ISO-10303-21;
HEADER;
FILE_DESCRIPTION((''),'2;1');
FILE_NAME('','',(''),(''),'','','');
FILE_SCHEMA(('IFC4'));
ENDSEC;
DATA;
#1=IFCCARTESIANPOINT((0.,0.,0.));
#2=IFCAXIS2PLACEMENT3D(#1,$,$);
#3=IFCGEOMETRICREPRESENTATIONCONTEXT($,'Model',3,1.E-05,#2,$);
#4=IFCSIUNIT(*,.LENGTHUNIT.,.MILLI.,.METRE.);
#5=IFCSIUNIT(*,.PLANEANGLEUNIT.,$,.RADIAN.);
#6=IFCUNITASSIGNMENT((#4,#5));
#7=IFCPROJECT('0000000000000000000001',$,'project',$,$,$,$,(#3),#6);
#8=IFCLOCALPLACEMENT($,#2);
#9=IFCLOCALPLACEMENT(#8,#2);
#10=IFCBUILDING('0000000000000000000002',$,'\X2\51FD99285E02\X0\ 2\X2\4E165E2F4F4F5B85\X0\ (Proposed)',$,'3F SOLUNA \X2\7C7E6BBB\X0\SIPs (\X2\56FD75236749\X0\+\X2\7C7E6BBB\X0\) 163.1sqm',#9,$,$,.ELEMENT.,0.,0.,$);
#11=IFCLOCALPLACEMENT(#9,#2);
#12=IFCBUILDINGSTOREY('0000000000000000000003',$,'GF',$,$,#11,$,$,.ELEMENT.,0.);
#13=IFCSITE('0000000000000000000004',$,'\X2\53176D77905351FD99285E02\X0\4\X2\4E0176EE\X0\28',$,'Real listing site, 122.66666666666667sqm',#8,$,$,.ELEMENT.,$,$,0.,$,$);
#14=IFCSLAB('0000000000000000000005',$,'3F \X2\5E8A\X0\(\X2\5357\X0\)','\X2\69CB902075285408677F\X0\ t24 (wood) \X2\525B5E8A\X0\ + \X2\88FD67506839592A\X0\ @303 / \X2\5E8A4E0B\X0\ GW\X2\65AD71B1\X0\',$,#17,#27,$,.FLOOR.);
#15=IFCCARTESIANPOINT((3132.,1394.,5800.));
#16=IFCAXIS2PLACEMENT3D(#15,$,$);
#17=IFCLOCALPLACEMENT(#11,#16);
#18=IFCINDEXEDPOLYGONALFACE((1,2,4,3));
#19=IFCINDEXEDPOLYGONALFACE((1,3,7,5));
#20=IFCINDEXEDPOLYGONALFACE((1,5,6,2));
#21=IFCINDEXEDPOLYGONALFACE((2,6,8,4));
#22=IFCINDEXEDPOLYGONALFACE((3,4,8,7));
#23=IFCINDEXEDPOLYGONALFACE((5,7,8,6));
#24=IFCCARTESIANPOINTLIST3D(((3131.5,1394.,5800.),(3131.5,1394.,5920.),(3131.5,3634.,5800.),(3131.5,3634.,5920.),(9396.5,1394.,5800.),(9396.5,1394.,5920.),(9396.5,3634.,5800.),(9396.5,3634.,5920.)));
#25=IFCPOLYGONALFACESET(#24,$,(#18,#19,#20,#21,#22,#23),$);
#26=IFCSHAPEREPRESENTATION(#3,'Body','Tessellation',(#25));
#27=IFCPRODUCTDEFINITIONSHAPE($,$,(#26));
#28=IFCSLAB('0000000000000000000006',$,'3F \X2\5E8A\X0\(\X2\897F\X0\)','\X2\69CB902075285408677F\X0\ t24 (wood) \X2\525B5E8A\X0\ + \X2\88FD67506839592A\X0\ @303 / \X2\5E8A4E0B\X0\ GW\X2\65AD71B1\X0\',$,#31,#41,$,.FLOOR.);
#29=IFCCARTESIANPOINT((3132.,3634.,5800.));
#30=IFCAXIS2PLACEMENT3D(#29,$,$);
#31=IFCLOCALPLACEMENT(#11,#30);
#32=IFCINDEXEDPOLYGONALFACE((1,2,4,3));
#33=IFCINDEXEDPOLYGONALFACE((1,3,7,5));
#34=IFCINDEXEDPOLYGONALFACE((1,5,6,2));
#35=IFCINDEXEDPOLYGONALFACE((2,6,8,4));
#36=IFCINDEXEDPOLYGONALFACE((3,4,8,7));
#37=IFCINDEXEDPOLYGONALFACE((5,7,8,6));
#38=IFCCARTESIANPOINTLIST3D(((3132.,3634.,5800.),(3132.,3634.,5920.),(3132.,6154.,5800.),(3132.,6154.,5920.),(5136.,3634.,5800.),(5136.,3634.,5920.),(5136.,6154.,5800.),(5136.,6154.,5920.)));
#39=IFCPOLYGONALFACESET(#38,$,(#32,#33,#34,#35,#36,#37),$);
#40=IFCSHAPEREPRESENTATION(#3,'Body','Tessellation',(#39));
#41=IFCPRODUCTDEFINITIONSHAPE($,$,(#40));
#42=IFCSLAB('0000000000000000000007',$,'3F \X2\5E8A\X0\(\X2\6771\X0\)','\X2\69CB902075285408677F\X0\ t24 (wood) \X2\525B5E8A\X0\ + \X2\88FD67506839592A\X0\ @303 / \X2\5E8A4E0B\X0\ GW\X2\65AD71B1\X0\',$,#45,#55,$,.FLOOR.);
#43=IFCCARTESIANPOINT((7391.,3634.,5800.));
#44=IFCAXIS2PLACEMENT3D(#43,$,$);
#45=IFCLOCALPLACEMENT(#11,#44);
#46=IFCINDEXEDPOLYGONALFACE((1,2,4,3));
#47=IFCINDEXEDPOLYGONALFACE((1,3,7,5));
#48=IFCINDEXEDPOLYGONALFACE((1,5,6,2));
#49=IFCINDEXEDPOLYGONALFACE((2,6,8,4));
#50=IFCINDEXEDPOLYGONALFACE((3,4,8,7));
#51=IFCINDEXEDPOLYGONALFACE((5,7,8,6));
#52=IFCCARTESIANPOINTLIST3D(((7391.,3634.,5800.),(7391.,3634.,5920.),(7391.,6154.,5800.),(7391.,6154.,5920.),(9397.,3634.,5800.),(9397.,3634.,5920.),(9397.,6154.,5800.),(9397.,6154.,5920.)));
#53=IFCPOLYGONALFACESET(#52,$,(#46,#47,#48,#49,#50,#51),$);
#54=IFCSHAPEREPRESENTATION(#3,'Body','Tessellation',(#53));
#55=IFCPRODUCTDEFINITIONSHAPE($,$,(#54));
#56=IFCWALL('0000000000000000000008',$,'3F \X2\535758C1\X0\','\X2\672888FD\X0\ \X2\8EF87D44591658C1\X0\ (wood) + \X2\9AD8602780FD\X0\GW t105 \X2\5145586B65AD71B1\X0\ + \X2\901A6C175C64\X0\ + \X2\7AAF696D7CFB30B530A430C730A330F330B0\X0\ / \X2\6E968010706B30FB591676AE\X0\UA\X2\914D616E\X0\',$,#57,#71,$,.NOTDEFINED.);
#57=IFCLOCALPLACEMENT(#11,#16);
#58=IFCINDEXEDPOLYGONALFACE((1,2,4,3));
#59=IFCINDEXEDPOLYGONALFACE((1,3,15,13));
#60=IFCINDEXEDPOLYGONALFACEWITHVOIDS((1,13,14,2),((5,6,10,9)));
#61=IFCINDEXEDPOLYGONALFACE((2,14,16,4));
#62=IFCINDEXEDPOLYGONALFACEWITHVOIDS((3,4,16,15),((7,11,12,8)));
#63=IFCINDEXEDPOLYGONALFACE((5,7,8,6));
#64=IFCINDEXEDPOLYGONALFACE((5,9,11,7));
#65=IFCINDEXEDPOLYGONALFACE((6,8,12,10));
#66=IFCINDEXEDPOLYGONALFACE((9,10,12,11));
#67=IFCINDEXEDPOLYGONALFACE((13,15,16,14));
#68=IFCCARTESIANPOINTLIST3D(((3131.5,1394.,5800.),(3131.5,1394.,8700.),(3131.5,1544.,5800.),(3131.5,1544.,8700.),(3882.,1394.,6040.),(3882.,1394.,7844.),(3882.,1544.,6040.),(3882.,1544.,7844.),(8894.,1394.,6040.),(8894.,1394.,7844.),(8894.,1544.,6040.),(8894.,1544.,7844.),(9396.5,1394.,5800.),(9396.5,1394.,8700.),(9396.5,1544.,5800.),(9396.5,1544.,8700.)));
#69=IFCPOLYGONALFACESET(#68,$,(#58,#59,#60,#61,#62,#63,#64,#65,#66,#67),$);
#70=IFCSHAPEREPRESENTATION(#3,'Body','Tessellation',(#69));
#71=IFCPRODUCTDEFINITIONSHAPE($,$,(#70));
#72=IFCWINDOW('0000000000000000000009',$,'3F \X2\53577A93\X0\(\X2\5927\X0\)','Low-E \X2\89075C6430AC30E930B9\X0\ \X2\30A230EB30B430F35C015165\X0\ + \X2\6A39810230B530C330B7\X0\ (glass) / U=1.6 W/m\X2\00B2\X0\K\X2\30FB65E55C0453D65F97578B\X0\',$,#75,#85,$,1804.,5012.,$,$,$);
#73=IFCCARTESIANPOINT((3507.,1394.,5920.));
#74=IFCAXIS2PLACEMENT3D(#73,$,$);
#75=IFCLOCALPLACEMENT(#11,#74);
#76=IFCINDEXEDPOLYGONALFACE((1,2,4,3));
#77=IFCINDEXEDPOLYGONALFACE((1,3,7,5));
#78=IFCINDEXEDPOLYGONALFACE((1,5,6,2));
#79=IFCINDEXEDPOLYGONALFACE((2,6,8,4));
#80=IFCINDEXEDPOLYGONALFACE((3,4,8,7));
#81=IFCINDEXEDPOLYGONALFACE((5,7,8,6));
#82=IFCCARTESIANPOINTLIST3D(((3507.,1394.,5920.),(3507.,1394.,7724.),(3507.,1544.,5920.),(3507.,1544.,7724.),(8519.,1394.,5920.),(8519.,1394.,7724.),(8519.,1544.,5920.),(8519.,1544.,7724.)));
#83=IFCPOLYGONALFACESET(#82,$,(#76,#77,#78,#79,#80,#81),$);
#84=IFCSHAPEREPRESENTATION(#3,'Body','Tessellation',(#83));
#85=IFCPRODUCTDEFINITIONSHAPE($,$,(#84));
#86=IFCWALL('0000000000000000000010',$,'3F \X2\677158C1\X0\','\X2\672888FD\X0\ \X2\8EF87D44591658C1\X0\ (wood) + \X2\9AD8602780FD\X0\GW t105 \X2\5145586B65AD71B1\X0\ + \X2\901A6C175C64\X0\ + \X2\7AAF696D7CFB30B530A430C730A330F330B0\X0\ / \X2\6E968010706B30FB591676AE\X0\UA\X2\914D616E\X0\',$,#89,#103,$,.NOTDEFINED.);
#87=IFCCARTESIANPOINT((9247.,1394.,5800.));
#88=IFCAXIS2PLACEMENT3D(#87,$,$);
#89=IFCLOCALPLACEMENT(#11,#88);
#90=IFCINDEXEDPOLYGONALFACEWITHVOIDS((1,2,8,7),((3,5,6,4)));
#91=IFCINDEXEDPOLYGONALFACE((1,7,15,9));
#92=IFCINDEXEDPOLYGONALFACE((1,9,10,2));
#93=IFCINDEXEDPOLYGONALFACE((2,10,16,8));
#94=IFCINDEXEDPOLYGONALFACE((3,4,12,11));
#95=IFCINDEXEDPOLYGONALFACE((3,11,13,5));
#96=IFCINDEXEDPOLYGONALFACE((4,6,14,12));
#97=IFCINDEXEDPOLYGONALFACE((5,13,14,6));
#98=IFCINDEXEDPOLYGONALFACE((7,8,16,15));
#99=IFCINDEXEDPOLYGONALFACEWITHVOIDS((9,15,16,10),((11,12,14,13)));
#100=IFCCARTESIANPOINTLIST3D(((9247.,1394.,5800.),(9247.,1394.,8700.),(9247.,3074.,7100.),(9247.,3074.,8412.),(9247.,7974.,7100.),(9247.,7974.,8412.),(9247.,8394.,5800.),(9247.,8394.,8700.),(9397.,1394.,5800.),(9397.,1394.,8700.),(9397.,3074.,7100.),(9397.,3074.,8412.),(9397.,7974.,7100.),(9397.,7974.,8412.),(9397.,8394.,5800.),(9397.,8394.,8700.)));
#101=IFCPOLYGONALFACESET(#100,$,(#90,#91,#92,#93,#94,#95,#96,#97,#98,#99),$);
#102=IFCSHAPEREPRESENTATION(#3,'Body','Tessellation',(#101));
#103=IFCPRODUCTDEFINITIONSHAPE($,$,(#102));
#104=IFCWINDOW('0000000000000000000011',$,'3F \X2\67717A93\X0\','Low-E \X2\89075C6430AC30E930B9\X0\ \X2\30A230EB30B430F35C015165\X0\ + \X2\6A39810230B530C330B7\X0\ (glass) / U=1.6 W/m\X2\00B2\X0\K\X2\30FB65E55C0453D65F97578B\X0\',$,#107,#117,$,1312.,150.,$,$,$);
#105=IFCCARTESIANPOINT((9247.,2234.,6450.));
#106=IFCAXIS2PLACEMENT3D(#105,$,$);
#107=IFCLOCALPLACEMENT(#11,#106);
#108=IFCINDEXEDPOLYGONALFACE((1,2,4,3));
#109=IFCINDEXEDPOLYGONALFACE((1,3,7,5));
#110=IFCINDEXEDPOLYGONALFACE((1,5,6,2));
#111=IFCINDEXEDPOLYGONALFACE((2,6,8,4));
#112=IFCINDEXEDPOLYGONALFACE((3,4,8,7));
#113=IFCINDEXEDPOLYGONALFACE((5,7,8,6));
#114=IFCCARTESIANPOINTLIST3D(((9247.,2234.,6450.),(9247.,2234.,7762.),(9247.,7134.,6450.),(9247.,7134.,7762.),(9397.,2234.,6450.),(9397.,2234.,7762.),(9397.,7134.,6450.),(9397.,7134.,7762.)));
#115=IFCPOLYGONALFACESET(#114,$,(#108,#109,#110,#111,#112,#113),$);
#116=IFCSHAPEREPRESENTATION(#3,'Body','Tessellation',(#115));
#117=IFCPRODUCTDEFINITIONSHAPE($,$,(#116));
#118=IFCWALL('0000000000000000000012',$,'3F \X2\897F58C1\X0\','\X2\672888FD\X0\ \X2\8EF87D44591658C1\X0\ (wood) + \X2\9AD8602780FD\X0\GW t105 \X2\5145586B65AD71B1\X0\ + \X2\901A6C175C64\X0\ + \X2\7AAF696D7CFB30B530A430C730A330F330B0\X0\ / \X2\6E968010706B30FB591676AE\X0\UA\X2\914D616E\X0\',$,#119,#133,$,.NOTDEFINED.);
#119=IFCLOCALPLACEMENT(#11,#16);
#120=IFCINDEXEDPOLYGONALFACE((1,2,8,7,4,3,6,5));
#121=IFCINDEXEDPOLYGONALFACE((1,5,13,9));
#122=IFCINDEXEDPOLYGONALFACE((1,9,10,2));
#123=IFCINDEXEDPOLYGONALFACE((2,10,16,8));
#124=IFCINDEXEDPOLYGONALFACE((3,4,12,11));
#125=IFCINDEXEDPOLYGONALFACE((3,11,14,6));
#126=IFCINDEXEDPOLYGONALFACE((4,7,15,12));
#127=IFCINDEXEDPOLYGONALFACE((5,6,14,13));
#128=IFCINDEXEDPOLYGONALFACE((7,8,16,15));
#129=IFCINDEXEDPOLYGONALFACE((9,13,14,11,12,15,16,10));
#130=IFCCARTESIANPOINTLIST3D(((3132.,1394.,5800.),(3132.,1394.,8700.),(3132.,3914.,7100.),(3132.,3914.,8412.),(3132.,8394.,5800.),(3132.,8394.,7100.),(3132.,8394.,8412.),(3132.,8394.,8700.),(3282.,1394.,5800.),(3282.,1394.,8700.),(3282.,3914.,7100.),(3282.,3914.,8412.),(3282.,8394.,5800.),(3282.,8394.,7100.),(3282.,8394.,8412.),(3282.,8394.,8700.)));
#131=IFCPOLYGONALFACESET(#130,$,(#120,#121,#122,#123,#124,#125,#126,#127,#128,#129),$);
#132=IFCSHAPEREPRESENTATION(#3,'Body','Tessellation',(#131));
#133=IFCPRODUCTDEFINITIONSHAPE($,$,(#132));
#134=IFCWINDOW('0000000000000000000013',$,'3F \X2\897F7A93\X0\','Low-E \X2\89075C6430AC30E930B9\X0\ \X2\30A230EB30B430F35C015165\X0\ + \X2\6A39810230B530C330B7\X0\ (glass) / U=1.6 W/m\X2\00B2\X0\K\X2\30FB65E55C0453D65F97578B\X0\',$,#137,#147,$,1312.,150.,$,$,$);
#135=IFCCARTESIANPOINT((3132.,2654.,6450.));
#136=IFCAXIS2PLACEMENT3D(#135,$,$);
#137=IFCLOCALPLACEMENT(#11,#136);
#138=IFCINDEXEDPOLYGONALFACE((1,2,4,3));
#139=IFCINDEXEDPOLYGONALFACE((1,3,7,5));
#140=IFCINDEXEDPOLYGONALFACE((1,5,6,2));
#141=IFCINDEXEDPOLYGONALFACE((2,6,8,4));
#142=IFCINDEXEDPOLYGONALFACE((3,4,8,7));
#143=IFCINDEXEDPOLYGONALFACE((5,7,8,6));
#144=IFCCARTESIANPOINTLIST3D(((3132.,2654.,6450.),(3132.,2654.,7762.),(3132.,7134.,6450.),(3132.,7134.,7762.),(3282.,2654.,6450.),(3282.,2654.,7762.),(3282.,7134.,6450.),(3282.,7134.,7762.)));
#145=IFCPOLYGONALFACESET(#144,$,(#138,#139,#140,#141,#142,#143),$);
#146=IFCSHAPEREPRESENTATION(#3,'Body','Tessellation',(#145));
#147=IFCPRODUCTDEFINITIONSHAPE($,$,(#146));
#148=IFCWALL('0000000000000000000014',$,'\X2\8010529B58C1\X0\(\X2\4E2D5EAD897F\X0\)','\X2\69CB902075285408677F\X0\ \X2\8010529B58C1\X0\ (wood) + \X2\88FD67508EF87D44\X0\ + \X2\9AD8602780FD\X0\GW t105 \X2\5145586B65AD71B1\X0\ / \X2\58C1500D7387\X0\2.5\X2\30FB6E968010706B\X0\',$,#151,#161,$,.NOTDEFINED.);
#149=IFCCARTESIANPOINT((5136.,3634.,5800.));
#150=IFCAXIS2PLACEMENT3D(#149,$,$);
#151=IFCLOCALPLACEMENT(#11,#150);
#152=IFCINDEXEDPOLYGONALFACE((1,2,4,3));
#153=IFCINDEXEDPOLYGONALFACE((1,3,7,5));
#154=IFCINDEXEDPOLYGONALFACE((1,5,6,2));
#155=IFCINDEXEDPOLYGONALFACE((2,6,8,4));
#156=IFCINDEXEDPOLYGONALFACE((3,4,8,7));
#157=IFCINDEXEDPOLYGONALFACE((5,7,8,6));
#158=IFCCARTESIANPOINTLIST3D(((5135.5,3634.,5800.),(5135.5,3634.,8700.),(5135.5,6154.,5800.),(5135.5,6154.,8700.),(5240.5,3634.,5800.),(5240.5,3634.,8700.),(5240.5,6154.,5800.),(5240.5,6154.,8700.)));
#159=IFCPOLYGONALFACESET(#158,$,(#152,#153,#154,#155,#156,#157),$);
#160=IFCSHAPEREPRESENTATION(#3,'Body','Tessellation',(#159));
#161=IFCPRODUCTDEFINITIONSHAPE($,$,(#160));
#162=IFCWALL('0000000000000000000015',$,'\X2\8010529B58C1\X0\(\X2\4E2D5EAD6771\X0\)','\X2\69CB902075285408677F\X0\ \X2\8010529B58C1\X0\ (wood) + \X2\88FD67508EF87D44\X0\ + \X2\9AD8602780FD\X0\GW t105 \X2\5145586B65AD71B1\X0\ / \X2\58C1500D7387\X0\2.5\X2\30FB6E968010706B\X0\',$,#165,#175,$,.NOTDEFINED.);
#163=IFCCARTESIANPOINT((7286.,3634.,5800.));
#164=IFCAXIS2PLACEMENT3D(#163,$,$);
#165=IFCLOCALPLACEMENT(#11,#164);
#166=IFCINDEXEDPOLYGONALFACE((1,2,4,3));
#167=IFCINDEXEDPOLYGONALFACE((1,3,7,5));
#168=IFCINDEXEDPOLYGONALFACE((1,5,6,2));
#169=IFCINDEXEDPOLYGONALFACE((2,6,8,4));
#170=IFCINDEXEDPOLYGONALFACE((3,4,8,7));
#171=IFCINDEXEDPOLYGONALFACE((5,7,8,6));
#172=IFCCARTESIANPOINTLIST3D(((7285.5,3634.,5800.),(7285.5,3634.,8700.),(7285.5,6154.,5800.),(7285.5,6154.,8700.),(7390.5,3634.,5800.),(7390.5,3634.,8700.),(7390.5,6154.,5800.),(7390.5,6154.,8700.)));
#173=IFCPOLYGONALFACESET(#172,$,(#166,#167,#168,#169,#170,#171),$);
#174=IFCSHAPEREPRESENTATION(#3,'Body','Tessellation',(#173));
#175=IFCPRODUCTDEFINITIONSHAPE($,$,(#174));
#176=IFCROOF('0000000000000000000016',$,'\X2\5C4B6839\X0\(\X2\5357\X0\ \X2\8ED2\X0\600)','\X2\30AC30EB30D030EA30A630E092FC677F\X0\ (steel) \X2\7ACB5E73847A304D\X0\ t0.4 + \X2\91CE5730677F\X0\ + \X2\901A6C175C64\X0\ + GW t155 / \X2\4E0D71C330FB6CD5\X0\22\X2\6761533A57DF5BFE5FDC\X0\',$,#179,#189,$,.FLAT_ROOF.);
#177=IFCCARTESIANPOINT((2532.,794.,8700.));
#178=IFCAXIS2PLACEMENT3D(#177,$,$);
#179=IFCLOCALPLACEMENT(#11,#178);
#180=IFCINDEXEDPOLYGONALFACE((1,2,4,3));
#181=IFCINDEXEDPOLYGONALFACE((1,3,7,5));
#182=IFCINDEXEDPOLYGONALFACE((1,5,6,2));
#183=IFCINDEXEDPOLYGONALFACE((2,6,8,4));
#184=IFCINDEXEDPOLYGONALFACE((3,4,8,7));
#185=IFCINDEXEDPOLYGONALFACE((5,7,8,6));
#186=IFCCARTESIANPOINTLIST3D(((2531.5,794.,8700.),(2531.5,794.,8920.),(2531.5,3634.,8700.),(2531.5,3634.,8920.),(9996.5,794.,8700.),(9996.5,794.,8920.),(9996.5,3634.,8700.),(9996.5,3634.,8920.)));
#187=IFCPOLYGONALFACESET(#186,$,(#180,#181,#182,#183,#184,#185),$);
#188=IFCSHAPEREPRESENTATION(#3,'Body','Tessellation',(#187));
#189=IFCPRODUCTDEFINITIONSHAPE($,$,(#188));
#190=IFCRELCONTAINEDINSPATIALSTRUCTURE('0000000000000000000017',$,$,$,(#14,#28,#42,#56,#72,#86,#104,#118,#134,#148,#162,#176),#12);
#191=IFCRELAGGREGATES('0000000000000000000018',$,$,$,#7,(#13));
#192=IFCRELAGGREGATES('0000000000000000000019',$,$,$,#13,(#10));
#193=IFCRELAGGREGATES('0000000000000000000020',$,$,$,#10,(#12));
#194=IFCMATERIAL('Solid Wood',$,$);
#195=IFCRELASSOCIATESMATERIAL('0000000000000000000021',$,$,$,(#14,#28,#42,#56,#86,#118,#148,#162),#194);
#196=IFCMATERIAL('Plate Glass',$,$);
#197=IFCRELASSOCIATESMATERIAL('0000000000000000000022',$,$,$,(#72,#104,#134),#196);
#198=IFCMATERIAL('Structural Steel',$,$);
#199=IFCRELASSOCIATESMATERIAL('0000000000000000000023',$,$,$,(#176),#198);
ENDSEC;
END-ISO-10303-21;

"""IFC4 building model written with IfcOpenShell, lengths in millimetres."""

from ifc_helpers import new_model, si_unit, frame, frame_2d, origin, place, context, project, spatial, rectangle, extrude, material, element, fill, save


model = new_model("IFC4")

# Units and contexts
model_context = context("Model", 3, precision=1e-05, world=origin())
ifc_project = project(units=[si_unit("LENGTHUNIT", "METRE", prefix="MILLI"), si_unit("PLANEANGLEUNIT", "RADIAN")], contexts=[model_context])

# Site, building, storey
site_placement = place(None, origin())
site = spatial("IfcSite", under=ifc_project, at=site_placement, Name="北海道函館市4丁目28", ObjectType="Real listing site, 122.66666666666667sqm", CompositionType="ELEMENT", RefElevation=0.0)
building_placement = place(site_placement, origin())
building = spatial("IfcBuilding", under=site, at=building_placement, Name="函館市 2世帯住宅 (Proposed)", ObjectType="3F SOLUNA 籾殻SIPs (国産杉+籾殻) 163.1sqm", CompositionType="ELEMENT", ElevationOfRefHeight=0.0, ElevationOfTerrain=0.0)
storey_placement = place(building_placement, origin())
storey = spatial("IfcBuildingStorey", under=building, at=storey_placement, Name="GF", CompositionType="ELEMENT", Elevation=0.0)

# Slabs
ifc_material_1 = material(Name="Solid Wood")
slab_1_placement = place(storey_placement, frame((3132.0, 1394.0, 5800.0)))
element("IfcSlab", 1, at=slab_1_placement, inside=storey, material=ifc_material_1, Name="3F 床(南)", Description="構造用合板 t24 (wood) 剛床 + 製材根太 @303 / 床下 GW断熱", PredefinedType="FLOOR", context=model_context, shape_type="SweptSolid", body=[
    extrude(rectangle(XDim=6265.0, YDim=2240.0, at=frame_2d((3132.0, 1120.0))), frame((3132.0, 1394.0, 5800.0)), (0.0, 0.0, 1.0), 120.0),
])
slab_2_placement = place(storey_placement, frame((3132.0, 3634.0, 5800.0)))
element("IfcSlab", 2, at=slab_2_placement, inside=storey, material=ifc_material_1, Name="3F 床(西)", Description="構造用合板 t24 (wood) 剛床 + 製材根太 @303 / 床下 GW断熱", PredefinedType="FLOOR", context=model_context, shape_type="SweptSolid", body=[
    extrude(rectangle(XDim=2004.0, YDim=2520.0, at=frame_2d((1002.0, 1260.0))), frame((3132.0, 3634.0, 5800.0)), (0.0, 0.0, 1.0), 120.0),
])
slab_3_placement = place(storey_placement, frame((7391.0, 3634.0, 5800.0)))
element("IfcSlab", 3, at=slab_3_placement, inside=storey, material=ifc_material_1, Name="3F 床(東)", Description="構造用合板 t24 (wood) 剛床 + 製材根太 @303 / 床下 GW断熱", PredefinedType="FLOOR", context=model_context, shape_type="SweptSolid", body=[
    extrude(rectangle(XDim=2006.0, YDim=2520.0, at=frame_2d((1003.0, 1260.0))), frame((7391.0, 3634.0, 5800.0)), (0.0, 0.0, 1.0), 120.0),
])

# Walls, openings, windows
wall_1_placement = place(storey_placement, frame((3132.0, 1394.0, 5800.0)))
wall_1 = element("IfcWall", 4, at=wall_1_placement, inside=storey, material=ifc_material_1, Name="3F 南壁", Description="木製 軸組外壁 (wood) + 高性能GW t105 充填断熱 + 通気層 + 窯業系サイディング / 準耐火・外皮UA配慮", PredefinedType="NOTDEFINED", context=model_context, shape_type="SweptSolid", body=[
    extrude(rectangle(XDim=6265.0, YDim=150.0, at=frame_2d((3132.0, 75.0))), frame((3132.0, 1394.0, 5800.0)), (0.0, 0.0, 1.0), 2900.0),
])
opening_1_placement = place(storey_placement, frame((3507.0, 1394.0, 5920.0)))
opening_1 = element("IfcOpeningElement", 5, at=opening_1_placement, cuts=wall_1, PredefinedType="NOTDEFINED", context=model_context, shape_type="SweptSolid", body=[
    extrude(rectangle(XDim=5012.0, YDim=150.0, at=frame_2d((2506.0, 75.0))), frame((3507.0, 1394.0, 5920.0)), (0.0, 0.0, 1.0), 1804.0),
])
ifc_material_2 = material(Name="Plate Glass")
window_1_placement = place(storey_placement, frame((3507.0, 1394.0, 5920.0)))
window_1 = element("IfcWindow", 6, at=window_1_placement, inside=storey, material=ifc_material_2, Name="3F 南窓(大)", Description="Low-E 複層ガラス アルゴン封入 + 樹脂サッシ (glass) / U=1.6 W/m²K・日射取得型", OverallHeight=1804.0, OverallWidth=5012.0, context=model_context, shape_type="SweptSolid", body=[
    extrude(rectangle(XDim=5012.0, YDim=150.0, at=frame_2d((2506.0, 75.0))), frame((3507.0, 1394.0, 5920.0)), (0.0, 0.0, 1.0), 1804.0),
])
fill(opening_1, window_1)
wall_2_placement = place(storey_placement, frame((9247.0, 1394.0, 5800.0)))
wall_2 = element("IfcWall", 7, at=wall_2_placement, inside=storey, material=ifc_material_1, Name="3F 東壁", Description="木製 軸組外壁 (wood) + 高性能GW t105 充填断熱 + 通気層 + 窯業系サイディング / 準耐火・外皮UA配慮", PredefinedType="NOTDEFINED", context=model_context, shape_type="SweptSolid", body=[
    extrude(rectangle(XDim=150.0, YDim=7000.0, at=frame_2d((75.0, 3500.0))), frame((9247.0, 1394.0, 5800.0)), (0.0, 0.0, 1.0), 2900.0),
])
opening_2_placement = place(storey_placement, frame((9247.0, 2234.0, 6450.0)))
opening_2 = element("IfcOpeningElement", 8, at=opening_2_placement, cuts=wall_2, PredefinedType="NOTDEFINED", context=model_context, shape_type="SweptSolid", body=[
    extrude(rectangle(XDim=150.0, YDim=4900.0, at=frame_2d((75.0, 2450.0))), frame((9247.0, 2234.0, 6450.0)), (0.0, 0.0, 1.0), 1312.0),
])
window_2_placement = place(storey_placement, frame((9247.0, 2234.0, 6450.0)))
window_2 = element("IfcWindow", 9, at=window_2_placement, inside=storey, material=ifc_material_2, Name="3F 東窓", Description="Low-E 複層ガラス アルゴン封入 + 樹脂サッシ (glass) / U=1.6 W/m²K・日射取得型", OverallHeight=1312.0, OverallWidth=150.0, context=model_context, shape_type="SweptSolid", body=[
    extrude(rectangle(XDim=150.0, YDim=4900.0, at=frame_2d((75.0, 2450.0))), frame((9247.0, 2234.0, 6450.0)), (0.0, 0.0, 1.0), 1312.0),
])
fill(opening_2, window_2)
wall_3_placement = place(storey_placement, frame((3132.0, 1394.0, 5800.0)))
wall_3 = element("IfcWall", 10, at=wall_3_placement, inside=storey, material=ifc_material_1, Name="3F 西壁", Description="木製 軸組外壁 (wood) + 高性能GW t105 充填断熱 + 通気層 + 窯業系サイディング / 準耐火・外皮UA配慮", PredefinedType="NOTDEFINED", context=model_context, shape_type="SweptSolid", body=[
    extrude(rectangle(XDim=150.0, YDim=7000.0, at=frame_2d((75.0, 3500.0))), frame((3132.0, 1394.0, 5800.0)), (0.0, 0.0, 1.0), 2900.0),
])
opening_3_placement = place(storey_placement, frame((3132.0, 2654.0, 6450.0)))
opening_3 = element("IfcOpeningElement", 11, at=opening_3_placement, cuts=wall_3, PredefinedType="NOTDEFINED", context=model_context, shape_type="SweptSolid", body=[
    extrude(rectangle(XDim=150.0, YDim=4480.0, at=frame_2d((75.0, 2240.0))), frame((3132.0, 2654.0, 6450.0)), (0.0, 0.0, 1.0), 1312.0),
])
window_3_placement = place(storey_placement, frame((3132.0, 2654.0, 6450.0)))
window_3 = element("IfcWindow", 12, at=window_3_placement, inside=storey, material=ifc_material_2, Name="3F 西窓", Description="Low-E 複層ガラス アルゴン封入 + 樹脂サッシ (glass) / U=1.6 W/m²K・日射取得型", OverallHeight=1312.0, OverallWidth=150.0, context=model_context, shape_type="SweptSolid", body=[
    extrude(rectangle(XDim=150.0, YDim=4480.0, at=frame_2d((75.0, 2240.0))), frame((3132.0, 2654.0, 6450.0)), (0.0, 0.0, 1.0), 1312.0),
])
fill(opening_3, window_3)

# Walls
wall_4_placement = place(storey_placement, frame((5136.0, 3634.0, 5800.0)))
element("IfcWall", 13, at=wall_4_placement, inside=storey, material=ifc_material_1, Name="耐力壁(中庭西)", Description="構造用合板 耐力壁 (wood) + 製材軸組 + 高性能GW t105 充填断熱 / 壁倍率2.5・準耐火", PredefinedType="NOTDEFINED", context=model_context, shape_type="SweptSolid", body=[
    extrude(rectangle(XDim=105.0, YDim=2520.0, at=frame_2d((52.0, 1260.0))), frame((5136.0, 3634.0, 5800.0)), (0.0, 0.0, 1.0), 2900.0),
])
wall_5_placement = place(storey_placement, frame((7286.0, 3634.0, 5800.0)))
element("IfcWall", 14, at=wall_5_placement, inside=storey, material=ifc_material_1, Name="耐力壁(中庭東)", Description="構造用合板 耐力壁 (wood) + 製材軸組 + 高性能GW t105 充填断熱 / 壁倍率2.5・準耐火", PredefinedType="NOTDEFINED", context=model_context, shape_type="SweptSolid", body=[
    extrude(rectangle(XDim=105.0, YDim=2520.0, at=frame_2d((52.0, 1260.0))), frame((7286.0, 3634.0, 5800.0)), (0.0, 0.0, 1.0), 2900.0),
])

# Roof
ifc_material_3 = material(Name="Structural Steel")
roof_1_placement = place(storey_placement, frame((2532.0, 794.0, 8700.0)))
element("IfcRoof", 15, at=roof_1_placement, inside=storey, material=ifc_material_3, Name="屋根(南 軒600)", Description="ガルバリウム鋼板 (steel) 立平葺き t0.4 + 野地板 + 通気層 + GW t155 / 不燃・法22条区域対応", PredefinedType="FLAT_ROOF", context=model_context, shape_type="SweptSolid", body=[
    extrude(rectangle(XDim=7465.0, YDim=2840.0, at=frame_2d((3732.0, 1420.0))), frame((2532.0, 794.0, 8700.0)), (0.0, 0.0, 1.0), 220.0),
])

save(model, "model.ifc")
